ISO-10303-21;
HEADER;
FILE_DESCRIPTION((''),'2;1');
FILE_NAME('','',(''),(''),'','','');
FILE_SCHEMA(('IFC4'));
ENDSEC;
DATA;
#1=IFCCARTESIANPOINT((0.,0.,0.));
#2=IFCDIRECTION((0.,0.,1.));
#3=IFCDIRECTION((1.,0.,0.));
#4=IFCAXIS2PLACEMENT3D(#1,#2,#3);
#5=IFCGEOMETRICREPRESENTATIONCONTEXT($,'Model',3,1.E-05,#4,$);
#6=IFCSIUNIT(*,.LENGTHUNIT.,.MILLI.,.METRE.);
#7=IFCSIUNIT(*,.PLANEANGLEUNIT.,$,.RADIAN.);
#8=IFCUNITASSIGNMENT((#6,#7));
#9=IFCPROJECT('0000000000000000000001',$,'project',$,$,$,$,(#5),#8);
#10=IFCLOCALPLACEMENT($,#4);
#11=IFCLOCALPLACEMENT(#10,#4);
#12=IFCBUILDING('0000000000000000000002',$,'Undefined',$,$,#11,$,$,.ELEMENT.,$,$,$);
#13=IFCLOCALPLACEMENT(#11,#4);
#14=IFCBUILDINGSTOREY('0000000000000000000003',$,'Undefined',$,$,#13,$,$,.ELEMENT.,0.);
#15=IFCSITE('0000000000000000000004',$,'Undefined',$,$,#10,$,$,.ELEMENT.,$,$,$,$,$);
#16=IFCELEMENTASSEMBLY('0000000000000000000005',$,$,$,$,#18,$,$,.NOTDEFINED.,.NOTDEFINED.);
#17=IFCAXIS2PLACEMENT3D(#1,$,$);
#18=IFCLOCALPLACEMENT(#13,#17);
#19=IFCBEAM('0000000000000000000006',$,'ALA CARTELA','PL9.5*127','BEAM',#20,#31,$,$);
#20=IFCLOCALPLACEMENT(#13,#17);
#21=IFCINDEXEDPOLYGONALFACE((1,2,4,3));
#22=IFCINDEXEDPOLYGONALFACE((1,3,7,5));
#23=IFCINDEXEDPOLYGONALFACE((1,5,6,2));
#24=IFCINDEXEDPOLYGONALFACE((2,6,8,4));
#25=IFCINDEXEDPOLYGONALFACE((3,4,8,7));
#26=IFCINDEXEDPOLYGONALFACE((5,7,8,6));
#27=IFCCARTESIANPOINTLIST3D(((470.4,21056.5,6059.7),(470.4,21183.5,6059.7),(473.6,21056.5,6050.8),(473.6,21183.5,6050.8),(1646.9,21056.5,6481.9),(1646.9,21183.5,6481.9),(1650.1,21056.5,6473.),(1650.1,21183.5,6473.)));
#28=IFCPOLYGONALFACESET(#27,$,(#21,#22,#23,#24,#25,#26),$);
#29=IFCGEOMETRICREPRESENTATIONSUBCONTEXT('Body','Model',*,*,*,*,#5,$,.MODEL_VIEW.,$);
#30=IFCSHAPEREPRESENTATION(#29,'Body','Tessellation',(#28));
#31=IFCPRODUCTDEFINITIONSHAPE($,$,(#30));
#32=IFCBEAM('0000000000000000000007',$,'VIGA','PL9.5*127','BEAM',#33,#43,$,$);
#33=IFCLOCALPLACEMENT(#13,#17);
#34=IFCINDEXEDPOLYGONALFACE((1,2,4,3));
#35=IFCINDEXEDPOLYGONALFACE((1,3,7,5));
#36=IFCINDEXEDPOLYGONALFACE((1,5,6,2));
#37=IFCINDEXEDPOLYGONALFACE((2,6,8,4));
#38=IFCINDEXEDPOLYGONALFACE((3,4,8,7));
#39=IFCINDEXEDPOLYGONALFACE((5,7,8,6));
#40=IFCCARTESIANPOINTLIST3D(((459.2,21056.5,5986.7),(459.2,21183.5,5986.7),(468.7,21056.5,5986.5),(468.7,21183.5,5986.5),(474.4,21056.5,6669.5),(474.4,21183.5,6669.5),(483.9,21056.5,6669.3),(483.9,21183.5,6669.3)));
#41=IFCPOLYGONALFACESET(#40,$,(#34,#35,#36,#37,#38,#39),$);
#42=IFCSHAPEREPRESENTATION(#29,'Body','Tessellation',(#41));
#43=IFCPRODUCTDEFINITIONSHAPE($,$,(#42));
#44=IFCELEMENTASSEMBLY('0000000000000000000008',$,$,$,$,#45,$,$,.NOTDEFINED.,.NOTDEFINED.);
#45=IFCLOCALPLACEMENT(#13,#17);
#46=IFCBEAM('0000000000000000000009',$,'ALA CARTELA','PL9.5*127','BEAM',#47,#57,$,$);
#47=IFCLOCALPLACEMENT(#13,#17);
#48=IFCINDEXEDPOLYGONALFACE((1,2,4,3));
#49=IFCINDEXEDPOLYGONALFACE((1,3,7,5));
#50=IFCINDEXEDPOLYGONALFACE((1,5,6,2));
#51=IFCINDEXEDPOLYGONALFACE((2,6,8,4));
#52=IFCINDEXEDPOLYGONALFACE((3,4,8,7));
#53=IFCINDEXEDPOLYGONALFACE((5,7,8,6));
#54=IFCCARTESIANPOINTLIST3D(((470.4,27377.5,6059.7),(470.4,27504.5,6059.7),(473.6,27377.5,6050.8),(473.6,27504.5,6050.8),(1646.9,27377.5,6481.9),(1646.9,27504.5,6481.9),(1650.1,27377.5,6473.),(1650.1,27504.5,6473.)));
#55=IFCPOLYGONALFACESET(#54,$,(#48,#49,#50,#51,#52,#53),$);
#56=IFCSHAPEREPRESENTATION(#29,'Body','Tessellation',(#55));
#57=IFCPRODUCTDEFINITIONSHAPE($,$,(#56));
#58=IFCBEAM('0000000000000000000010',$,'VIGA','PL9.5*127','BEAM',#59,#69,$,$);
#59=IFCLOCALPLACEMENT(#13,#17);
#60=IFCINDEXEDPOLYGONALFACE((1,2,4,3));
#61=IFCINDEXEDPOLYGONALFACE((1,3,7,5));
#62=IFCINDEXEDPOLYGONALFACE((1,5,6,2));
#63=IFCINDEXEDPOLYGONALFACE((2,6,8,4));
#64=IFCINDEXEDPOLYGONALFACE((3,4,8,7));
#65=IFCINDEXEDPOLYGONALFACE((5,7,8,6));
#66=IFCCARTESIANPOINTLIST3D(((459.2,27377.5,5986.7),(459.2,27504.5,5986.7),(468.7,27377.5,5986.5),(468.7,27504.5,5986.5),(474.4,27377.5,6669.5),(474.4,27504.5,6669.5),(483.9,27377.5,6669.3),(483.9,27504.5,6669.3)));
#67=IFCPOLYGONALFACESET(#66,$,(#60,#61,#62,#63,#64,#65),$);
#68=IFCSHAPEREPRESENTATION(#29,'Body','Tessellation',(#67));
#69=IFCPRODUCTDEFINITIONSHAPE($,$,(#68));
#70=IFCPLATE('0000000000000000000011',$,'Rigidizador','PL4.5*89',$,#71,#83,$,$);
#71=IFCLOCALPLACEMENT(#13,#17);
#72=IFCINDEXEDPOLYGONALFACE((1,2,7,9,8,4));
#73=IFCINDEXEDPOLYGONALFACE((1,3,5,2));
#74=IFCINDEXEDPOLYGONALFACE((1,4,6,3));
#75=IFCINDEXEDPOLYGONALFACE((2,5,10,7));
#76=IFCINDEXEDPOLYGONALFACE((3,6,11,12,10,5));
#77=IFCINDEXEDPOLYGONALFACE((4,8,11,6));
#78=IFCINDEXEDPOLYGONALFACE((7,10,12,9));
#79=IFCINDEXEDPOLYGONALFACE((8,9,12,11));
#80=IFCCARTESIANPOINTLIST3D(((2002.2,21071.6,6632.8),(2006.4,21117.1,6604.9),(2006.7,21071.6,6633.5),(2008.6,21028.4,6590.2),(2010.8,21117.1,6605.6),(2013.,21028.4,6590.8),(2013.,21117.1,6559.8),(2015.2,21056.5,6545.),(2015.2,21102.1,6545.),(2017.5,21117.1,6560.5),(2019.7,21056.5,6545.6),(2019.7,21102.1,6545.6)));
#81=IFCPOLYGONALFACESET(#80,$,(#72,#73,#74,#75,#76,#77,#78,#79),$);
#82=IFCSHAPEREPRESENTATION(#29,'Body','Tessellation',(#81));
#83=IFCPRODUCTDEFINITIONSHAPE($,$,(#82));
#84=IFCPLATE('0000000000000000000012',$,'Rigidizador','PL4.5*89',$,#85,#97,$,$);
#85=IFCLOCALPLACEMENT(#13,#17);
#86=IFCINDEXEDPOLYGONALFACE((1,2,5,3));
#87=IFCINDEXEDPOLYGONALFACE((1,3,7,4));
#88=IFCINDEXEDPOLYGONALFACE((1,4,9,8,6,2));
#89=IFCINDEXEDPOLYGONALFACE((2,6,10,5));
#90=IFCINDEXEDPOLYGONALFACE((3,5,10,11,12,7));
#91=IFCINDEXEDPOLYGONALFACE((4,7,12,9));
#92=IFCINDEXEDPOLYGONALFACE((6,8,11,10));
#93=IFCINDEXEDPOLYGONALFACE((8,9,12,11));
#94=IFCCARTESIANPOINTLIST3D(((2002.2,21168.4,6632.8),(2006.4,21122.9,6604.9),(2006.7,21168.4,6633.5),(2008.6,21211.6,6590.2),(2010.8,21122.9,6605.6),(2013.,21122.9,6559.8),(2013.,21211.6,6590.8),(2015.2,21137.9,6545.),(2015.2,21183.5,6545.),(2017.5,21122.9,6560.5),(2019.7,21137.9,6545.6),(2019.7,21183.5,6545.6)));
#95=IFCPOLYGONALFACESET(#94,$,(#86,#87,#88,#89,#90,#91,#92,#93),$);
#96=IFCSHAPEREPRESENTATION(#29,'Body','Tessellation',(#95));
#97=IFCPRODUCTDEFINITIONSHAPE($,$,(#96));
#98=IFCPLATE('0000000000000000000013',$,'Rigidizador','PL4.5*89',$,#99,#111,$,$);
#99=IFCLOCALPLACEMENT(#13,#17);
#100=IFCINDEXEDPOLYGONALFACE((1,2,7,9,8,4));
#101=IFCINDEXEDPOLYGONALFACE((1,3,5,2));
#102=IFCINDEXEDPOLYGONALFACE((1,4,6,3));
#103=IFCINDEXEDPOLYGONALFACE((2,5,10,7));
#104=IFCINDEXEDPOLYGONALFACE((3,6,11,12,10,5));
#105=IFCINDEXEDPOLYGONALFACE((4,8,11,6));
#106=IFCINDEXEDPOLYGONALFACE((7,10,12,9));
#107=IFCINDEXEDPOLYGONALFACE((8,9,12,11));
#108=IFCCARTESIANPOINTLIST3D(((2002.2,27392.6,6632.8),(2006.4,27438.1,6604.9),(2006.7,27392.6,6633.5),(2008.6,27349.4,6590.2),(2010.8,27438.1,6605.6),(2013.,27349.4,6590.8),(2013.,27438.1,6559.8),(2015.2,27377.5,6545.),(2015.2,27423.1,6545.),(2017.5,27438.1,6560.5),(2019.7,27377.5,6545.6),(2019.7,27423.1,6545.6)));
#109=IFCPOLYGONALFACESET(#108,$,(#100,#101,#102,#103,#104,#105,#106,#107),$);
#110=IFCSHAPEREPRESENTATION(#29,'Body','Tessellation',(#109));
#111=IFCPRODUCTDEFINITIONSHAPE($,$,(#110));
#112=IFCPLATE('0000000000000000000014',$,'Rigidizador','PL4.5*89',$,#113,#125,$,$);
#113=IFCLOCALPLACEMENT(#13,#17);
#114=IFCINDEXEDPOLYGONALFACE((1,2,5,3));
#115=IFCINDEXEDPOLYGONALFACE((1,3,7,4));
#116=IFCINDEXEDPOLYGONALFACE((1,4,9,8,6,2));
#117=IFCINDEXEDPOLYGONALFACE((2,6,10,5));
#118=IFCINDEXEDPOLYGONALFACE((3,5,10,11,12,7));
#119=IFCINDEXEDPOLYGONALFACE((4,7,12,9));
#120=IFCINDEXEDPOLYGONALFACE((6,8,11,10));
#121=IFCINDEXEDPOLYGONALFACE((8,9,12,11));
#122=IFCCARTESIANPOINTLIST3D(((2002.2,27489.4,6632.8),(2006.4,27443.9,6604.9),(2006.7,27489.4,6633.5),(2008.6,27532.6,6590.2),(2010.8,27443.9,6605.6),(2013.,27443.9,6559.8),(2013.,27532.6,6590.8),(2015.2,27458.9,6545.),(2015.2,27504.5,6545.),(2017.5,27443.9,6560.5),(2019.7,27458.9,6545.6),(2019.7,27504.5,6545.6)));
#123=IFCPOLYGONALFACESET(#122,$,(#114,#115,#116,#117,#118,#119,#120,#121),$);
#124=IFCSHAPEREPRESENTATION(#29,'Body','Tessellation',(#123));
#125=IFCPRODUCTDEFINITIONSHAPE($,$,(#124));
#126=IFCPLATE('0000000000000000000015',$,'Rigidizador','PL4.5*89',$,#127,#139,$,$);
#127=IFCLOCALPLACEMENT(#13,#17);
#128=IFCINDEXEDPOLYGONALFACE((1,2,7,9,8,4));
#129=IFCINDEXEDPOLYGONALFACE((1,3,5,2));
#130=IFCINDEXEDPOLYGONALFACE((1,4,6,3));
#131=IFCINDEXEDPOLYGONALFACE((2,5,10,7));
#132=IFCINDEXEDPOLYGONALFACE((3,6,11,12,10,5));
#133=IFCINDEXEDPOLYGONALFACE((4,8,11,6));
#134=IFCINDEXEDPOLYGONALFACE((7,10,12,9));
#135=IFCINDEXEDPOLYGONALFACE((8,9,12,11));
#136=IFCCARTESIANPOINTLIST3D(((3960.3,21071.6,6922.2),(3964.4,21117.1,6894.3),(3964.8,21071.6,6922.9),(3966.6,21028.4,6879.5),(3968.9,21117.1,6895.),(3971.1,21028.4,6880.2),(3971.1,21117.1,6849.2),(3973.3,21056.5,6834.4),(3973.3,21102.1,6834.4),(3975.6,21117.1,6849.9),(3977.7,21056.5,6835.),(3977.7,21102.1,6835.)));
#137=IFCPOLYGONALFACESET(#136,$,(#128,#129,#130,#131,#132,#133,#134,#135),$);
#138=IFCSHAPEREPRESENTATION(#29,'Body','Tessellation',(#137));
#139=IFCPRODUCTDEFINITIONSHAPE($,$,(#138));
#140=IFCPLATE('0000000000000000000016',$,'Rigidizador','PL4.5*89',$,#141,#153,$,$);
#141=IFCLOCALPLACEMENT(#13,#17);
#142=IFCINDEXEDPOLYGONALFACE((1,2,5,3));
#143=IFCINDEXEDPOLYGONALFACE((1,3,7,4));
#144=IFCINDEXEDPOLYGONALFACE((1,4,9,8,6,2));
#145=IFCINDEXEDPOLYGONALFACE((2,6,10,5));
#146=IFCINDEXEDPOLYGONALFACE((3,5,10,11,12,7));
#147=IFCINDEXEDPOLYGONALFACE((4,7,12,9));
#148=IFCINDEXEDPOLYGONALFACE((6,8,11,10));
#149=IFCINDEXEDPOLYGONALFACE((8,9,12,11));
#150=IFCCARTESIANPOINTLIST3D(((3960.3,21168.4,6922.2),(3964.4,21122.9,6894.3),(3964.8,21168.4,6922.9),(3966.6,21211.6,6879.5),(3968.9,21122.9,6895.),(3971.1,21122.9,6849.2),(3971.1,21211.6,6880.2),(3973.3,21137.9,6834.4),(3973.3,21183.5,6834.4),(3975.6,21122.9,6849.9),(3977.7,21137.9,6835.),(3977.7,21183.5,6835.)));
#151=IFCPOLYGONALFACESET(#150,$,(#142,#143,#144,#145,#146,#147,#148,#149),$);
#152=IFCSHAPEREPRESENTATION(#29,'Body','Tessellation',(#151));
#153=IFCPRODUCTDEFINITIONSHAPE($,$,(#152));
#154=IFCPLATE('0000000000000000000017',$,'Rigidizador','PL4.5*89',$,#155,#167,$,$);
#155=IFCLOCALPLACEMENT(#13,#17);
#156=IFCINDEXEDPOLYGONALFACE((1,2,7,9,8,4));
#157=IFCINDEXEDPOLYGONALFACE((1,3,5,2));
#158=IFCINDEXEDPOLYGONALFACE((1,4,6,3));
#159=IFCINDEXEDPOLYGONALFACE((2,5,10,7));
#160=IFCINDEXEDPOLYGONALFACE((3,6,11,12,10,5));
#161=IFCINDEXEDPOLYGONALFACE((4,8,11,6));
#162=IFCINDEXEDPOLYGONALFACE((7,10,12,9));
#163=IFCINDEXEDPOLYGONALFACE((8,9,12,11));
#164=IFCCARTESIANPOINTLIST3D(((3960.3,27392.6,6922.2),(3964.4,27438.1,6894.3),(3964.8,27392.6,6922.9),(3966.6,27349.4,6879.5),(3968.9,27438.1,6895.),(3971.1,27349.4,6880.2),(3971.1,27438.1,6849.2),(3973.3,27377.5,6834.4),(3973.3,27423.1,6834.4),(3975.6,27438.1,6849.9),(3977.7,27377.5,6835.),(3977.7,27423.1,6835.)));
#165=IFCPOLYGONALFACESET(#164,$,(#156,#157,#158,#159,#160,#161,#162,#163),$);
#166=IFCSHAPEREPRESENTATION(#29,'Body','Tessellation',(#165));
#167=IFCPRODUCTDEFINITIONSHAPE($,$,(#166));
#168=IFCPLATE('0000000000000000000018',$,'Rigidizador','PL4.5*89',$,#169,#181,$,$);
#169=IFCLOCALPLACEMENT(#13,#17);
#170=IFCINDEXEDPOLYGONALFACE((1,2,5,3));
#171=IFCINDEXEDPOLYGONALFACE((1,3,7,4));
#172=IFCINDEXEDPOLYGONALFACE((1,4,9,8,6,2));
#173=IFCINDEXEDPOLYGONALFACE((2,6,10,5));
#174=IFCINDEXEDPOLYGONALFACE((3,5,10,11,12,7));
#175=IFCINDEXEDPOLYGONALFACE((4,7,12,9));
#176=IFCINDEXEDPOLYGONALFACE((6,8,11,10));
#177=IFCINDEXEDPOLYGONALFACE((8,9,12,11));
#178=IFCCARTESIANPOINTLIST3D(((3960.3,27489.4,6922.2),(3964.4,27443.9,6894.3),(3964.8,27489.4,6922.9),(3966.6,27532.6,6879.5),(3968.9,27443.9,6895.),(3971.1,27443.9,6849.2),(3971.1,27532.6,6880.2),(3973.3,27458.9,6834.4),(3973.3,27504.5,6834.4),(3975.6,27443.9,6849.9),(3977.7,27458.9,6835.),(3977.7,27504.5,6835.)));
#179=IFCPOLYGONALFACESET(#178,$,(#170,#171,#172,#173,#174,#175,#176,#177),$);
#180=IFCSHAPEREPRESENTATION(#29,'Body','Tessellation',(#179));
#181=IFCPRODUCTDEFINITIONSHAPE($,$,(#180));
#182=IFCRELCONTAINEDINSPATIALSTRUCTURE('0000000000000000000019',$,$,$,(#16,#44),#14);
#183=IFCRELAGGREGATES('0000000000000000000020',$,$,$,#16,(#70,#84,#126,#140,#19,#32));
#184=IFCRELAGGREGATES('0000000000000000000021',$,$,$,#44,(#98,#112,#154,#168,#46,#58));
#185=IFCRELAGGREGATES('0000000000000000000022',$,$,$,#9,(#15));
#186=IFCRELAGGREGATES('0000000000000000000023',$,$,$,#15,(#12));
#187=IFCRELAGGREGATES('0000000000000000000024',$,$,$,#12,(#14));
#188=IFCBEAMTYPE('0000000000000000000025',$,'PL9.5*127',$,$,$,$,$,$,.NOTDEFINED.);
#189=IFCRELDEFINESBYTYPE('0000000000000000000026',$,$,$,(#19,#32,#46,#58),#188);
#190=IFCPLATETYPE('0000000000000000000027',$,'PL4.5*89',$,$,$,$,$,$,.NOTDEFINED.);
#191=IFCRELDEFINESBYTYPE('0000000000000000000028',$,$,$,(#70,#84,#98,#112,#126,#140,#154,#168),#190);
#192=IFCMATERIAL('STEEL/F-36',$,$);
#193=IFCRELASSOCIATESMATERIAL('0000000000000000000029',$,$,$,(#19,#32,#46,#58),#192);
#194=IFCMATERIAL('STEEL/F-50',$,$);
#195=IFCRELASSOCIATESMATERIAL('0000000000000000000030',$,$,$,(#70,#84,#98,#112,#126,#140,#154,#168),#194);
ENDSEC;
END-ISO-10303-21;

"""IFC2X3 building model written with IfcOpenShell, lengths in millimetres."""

from ifc_helpers import new_model, si_unit, frame, origin_with_axes, origin_2d_with_axis, place, context, subcontext, project, spatial, polyline, rectangle, outline, extrude, material, type_object, element, aggregate, save


model = new_model("IFC2X3")

# Units and contexts
model_context = context("Model", 3, precision=1e-05, world=origin_with_axes())
body_context = subcontext(model_context, "Body", "Model", "MODEL_VIEW")
ifc_project = project(units=[si_unit("LENGTHUNIT", "METRE", prefix="MILLI"), si_unit("PLANEANGLEUNIT", "RADIAN")], contexts=[model_context])

# Site, building, storey
site_placement = place(None, origin_with_axes())
site = spatial("IfcSite", under=ifc_project, at=site_placement, Name="Undefined", CompositionType="ELEMENT")
building_placement = place(site_placement, origin_with_axes())
building = spatial("IfcBuilding", under=site, at=building_placement, Name="Undefined", CompositionType="ELEMENT")
storey_placement = place(building_placement, origin_with_axes())
storey = spatial("IfcBuildingStorey", under=building, at=storey_placement, Name="Undefined", CompositionType="ELEMENT", Elevation=0.0)

# Element assemblies, beams
assembly_1_placement = place(storey_placement, origin_with_axes())
assembly_1 = element("IfcElementAssembly", 1, at=assembly_1_placement, inside=storey, AssemblyPlace="NOTDEFINED", PredefinedType="NOTDEFINED")
ifc_material_1 = material(Name="STEEL/F-36")
beam_type = type_object("IfcBeamType", Name="PL9.5*127", PredefinedType="NOTDEFINED")
beam_1_placement = place(assembly_1_placement, frame((472.0, 21120.0, 6055.3), z_axis=(0.0, -1.0, 0.0), x_axis=(0.941227, 0.0, 0.337773)))
beam_1 = element("IfcBeam", 2, at=beam_1_placement, type_object=beam_type, material=ifc_material_1, Name="ALA CARTELA", Description="PL9.5*127", ObjectType="BEAM", context=body_context, shape_type="SweptSolid", body=[
    extrude(rectangle(XDim=9.5, YDim=127.0, at=origin_2d_with_axis()), frame((1250.0, 0.0, 0.0), z_axis=(-1.0, 0.0, 0.0), x_axis=(0.0, -1.0, 0.0)), (0.0, 0.0, 1.0), 1250.0),
])
beam_2_placement = place(assembly_1_placement, frame((479.1, 21120.0, 6669.4), z_axis=(0.0, 1.0, 0.0), x_axis=(-0.022184, 0.0, -0.999754)))
beam_2 = element("IfcBeam", 3, at=beam_2_placement, type_object=beam_type, material=ifc_material_1, Name="VIGA", Description="PL9.5*127", ObjectType="BEAM", context=body_context, shape_type="SweptSolid", body=[
    extrude(rectangle(XDim=9.5, YDim=127.0, at=origin_2d_with_axis()), frame((683.0, 0.0, 0.0), z_axis=(-1.0, 0.0, 0.0), x_axis=(0.0, -1.0, 0.0)), (0.0, 0.0, 1.0), 683.0),
])
assembly_2_placement = place(storey_placement, origin_with_axes())
assembly_2 = element("IfcElementAssembly", 4, at=assembly_2_placement, inside=storey, AssemblyPlace="NOTDEFINED", PredefinedType="NOTDEFINED")
beam_3_placement = place(assembly_2_placement, frame((472.0, 27441.0, 6055.3), z_axis=(0.0, -1.0, 0.0), x_axis=(0.941227, 0.0, 0.337773)))
beam_3 = element("IfcBeam", 5, at=beam_3_placement, type_object=beam_type, material=ifc_material_1, Name="ALA CARTELA", Description="PL9.5*127", ObjectType="BEAM", context=body_context, shape_type="SweptSolid", body=[
    extrude(rectangle(XDim=9.5, YDim=127.0, at=origin_2d_with_axis()), frame((1250.0, 0.0, 0.0), z_axis=(-1.0, 0.0, 0.0), x_axis=(0.0, -1.0, 0.0)), (0.0, 0.0, 1.0), 1250.0),
])
beam_4_placement = place(assembly_2_placement, frame((479.1, 27441.0, 6669.4), z_axis=(0.0, 1.0, 0.0), x_axis=(-0.022184, 0.0, -0.999754)))
beam_4 = element("IfcBeam", 6, at=beam_4_placement, type_object=beam_type, material=ifc_material_1, Name="VIGA", Description="PL9.5*127", ObjectType="BEAM", context=body_context, shape_type="SweptSolid", body=[
    extrude(rectangle(XDim=9.5, YDim=127.0, at=origin_2d_with_axis()), frame((683.0, 0.0, 0.0), z_axis=(-1.0, 0.0, 0.0), x_axis=(0.0, -1.0, 0.0)), (0.0, 0.0, 1.0), 683.0),
])

# Plates
ifc_material_2 = material(Name="STEEL/F-50")
plate_type_1 = type_object("IfcPlateType", Name="PL4.5*89", PredefinedType="NOTDEFINED")
plate_1_placement = place(assembly_1_placement, frame((2017.5, 21056.5, 6545.3), z_axis=(0.989255, 0.0, 0.146202), x_axis=(0.0, 1.0, 0.0)))
plate_1 = element("IfcPlate", 7, at=plate_1_placement, type_object=plate_type_1, material=ifc_material_2, Name="Rigidizador", Description="PL4.5*89", context=body_context, shape_type="SweptSolid", body=[
    extrude(outline(polyline([(0.0, 0.0), (45.6, 0.0), (60.6, 15.0), (60.6, 60.6), (15.1, 88.8), (-28.1, 45.7), (0.0, 0.0)])), frame((0.0, 0.0, -2.2), z_axis=(0.0, 0.0, 1.0), x_axis=(1.0, 0.0, 0.0)), (0.0, 0.0, 1.0), 4.5),
])
plate_2_placement = place(assembly_1_placement, frame((2017.5, 21183.5, 6545.3), z_axis=(-0.989255, 0.0, -0.146202), x_axis=(0.0, -1.0, 0.0)))
plate_2 = element("IfcPlate", 8, at=plate_2_placement, type_object=plate_type_1, material=ifc_material_2, Name="Rigidizador", Description="PL4.5*89", context=body_context, shape_type="SweptSolid", body=[
    extrude(outline(polyline([(0.0, 0.0), (45.6, 0.0), (60.6, 15.0), (60.6, 60.6), (15.1, 88.8), (-28.1, 45.7), (0.0, 0.0)])), frame((0.0, 0.0, -2.2), z_axis=(0.0, 0.0, 1.0), x_axis=(1.0, 0.0, 0.0)), (0.0, 0.0, 1.0), 4.5),
])
plate_3_placement = place(assembly_2_placement, frame((2017.5, 27377.5, 6545.3), z_axis=(0.989255, 0.0, 0.146202), x_axis=(0.0, 1.0, 0.0)))
plate_3 = element("IfcPlate", 9, at=plate_3_placement, type_object=plate_type_1, material=ifc_material_2, Name="Rigidizador", Description="PL4.5*89", context=body_context, shape_type="SweptSolid", body=[
    extrude(outline(polyline([(0.0, 0.0), (45.6, 0.0), (60.6, 15.0), (60.6, 60.6), (15.1, 88.8), (-28.1, 45.7), (0.0, 0.0)])), frame((0.0, 0.0, -2.2), z_axis=(0.0, 0.0, 1.0), x_axis=(1.0, 0.0, 0.0)), (0.0, 0.0, 1.0), 4.5),
])
plate_4_placement = place(assembly_2_placement, frame((2017.5, 27504.5, 6545.3), z_axis=(-0.989255, 0.0, -0.146202), x_axis=(0.0, -1.0, 0.0)))
plate_4 = element("IfcPlate", 10, at=plate_4_placement, type_object=plate_type_1, material=ifc_material_2, Name="Rigidizador", Description="PL4.5*89", context=body_context, shape_type="SweptSolid", body=[
    extrude(outline(polyline([(0.0, 0.0), (45.6, 0.0), (60.6, 15.0), (60.6, 60.6), (15.1, 88.8), (-28.1, 45.7), (0.0, 0.0)])), frame((0.0, 0.0, -2.2), z_axis=(0.0, 0.0, 1.0), x_axis=(1.0, 0.0, 0.0)), (0.0, 0.0, 1.0), 4.5),
])
plate_5_placement = place(assembly_1_placement, frame((3975.5, 21056.5, 6834.7), z_axis=(0.989255, 0.0, 0.146202), x_axis=(0.0, 1.0, 0.0)))
plate_5 = element("IfcPlate", 11, at=plate_5_placement, type_object=plate_type_1, material=ifc_material_2, Name="Rigidizador", Description="PL4.5*89", context=body_context, shape_type="SweptSolid", body=[
    extrude(outline(polyline([(0.0, 0.0), (45.6, 0.0), (60.6, 15.0), (60.6, 60.6), (15.1, 88.8), (-28.1, 45.7), (0.0, 0.0)])), frame((0.0, 0.0, -2.2), z_axis=(0.0, 0.0, 1.0), x_axis=(1.0, 0.0, 0.0)), (0.0, 0.0, 1.0), 4.5),
])
plate_6_placement = place(assembly_1_placement, frame((3975.5, 21183.5, 6834.7), z_axis=(-0.989255, 0.0, -0.146202), x_axis=(0.0, -1.0, 0.0)))
plate_6 = element("IfcPlate", 12, at=plate_6_placement, type_object=plate_type_1, material=ifc_material_2, Name="Rigidizador", Description="PL4.5*89", context=body_context, shape_type="SweptSolid", body=[
    extrude(outline(polyline([(0.0, 0.0), (45.6, 0.0), (60.6, 15.0), (60.6, 60.6), (15.1, 88.8), (-28.1, 45.7), (0.0, 0.0)])), frame((0.0, 0.0, -2.2), z_axis=(0.0, 0.0, 1.0), x_axis=(1.0, 0.0, 0.0)), (0.0, 0.0, 1.0), 4.5),
])
plate_7_placement = place(assembly_2_placement, frame((3975.5, 27377.5, 6834.7), z_axis=(0.989255, 0.0, 0.146202), x_axis=(0.0, 1.0, 0.0)))
plate_7 = element("IfcPlate", 13, at=plate_7_placement, type_object=plate_type_1, material=ifc_material_2, Name="Rigidizador", Description="PL4.5*89", context=body_context, shape_type="SweptSolid", body=[
    extrude(outline(polyline([(0.0, 0.0), (45.6, 0.0), (60.6, 15.0), (60.6, 60.6), (15.1, 88.8), (-28.1, 45.7), (0.0, 0.0)])), frame((0.0, 0.0, -2.2), z_axis=(0.0, 0.0, 1.0), x_axis=(1.0, 0.0, 0.0)), (0.0, 0.0, 1.0), 4.5),
])
plate_8_placement = place(assembly_2_placement, frame((3975.5, 27504.5, 6834.7), z_axis=(-0.989255, 0.0, -0.146202), x_axis=(0.0, -1.0, 0.0)))
plate_8 = element("IfcPlate", 14, at=plate_8_placement, type_object=plate_type_1, material=ifc_material_2, Name="Rigidizador", Description="PL4.5*89", context=body_context, shape_type="SweptSolid", body=[
    extrude(outline(polyline([(0.0, 0.0), (45.6, 0.0), (60.6, 15.0), (60.6, 60.6), (15.1, 88.8), (-28.1, 45.7), (0.0, 0.0)])), frame((0.0, 0.0, -2.2), z_axis=(0.0, 0.0, 1.0), x_axis=(1.0, 0.0, 0.0)), (0.0, 0.0, 1.0), 4.5),
])

aggregate(assembly_1, [plate_1, plate_2, plate_5, plate_6, beam_1, beam_2])
aggregate(assembly_2, [plate_3, plate_4, plate_7, plate_8, beam_3, beam_4])

save(model, "model.ifc")
